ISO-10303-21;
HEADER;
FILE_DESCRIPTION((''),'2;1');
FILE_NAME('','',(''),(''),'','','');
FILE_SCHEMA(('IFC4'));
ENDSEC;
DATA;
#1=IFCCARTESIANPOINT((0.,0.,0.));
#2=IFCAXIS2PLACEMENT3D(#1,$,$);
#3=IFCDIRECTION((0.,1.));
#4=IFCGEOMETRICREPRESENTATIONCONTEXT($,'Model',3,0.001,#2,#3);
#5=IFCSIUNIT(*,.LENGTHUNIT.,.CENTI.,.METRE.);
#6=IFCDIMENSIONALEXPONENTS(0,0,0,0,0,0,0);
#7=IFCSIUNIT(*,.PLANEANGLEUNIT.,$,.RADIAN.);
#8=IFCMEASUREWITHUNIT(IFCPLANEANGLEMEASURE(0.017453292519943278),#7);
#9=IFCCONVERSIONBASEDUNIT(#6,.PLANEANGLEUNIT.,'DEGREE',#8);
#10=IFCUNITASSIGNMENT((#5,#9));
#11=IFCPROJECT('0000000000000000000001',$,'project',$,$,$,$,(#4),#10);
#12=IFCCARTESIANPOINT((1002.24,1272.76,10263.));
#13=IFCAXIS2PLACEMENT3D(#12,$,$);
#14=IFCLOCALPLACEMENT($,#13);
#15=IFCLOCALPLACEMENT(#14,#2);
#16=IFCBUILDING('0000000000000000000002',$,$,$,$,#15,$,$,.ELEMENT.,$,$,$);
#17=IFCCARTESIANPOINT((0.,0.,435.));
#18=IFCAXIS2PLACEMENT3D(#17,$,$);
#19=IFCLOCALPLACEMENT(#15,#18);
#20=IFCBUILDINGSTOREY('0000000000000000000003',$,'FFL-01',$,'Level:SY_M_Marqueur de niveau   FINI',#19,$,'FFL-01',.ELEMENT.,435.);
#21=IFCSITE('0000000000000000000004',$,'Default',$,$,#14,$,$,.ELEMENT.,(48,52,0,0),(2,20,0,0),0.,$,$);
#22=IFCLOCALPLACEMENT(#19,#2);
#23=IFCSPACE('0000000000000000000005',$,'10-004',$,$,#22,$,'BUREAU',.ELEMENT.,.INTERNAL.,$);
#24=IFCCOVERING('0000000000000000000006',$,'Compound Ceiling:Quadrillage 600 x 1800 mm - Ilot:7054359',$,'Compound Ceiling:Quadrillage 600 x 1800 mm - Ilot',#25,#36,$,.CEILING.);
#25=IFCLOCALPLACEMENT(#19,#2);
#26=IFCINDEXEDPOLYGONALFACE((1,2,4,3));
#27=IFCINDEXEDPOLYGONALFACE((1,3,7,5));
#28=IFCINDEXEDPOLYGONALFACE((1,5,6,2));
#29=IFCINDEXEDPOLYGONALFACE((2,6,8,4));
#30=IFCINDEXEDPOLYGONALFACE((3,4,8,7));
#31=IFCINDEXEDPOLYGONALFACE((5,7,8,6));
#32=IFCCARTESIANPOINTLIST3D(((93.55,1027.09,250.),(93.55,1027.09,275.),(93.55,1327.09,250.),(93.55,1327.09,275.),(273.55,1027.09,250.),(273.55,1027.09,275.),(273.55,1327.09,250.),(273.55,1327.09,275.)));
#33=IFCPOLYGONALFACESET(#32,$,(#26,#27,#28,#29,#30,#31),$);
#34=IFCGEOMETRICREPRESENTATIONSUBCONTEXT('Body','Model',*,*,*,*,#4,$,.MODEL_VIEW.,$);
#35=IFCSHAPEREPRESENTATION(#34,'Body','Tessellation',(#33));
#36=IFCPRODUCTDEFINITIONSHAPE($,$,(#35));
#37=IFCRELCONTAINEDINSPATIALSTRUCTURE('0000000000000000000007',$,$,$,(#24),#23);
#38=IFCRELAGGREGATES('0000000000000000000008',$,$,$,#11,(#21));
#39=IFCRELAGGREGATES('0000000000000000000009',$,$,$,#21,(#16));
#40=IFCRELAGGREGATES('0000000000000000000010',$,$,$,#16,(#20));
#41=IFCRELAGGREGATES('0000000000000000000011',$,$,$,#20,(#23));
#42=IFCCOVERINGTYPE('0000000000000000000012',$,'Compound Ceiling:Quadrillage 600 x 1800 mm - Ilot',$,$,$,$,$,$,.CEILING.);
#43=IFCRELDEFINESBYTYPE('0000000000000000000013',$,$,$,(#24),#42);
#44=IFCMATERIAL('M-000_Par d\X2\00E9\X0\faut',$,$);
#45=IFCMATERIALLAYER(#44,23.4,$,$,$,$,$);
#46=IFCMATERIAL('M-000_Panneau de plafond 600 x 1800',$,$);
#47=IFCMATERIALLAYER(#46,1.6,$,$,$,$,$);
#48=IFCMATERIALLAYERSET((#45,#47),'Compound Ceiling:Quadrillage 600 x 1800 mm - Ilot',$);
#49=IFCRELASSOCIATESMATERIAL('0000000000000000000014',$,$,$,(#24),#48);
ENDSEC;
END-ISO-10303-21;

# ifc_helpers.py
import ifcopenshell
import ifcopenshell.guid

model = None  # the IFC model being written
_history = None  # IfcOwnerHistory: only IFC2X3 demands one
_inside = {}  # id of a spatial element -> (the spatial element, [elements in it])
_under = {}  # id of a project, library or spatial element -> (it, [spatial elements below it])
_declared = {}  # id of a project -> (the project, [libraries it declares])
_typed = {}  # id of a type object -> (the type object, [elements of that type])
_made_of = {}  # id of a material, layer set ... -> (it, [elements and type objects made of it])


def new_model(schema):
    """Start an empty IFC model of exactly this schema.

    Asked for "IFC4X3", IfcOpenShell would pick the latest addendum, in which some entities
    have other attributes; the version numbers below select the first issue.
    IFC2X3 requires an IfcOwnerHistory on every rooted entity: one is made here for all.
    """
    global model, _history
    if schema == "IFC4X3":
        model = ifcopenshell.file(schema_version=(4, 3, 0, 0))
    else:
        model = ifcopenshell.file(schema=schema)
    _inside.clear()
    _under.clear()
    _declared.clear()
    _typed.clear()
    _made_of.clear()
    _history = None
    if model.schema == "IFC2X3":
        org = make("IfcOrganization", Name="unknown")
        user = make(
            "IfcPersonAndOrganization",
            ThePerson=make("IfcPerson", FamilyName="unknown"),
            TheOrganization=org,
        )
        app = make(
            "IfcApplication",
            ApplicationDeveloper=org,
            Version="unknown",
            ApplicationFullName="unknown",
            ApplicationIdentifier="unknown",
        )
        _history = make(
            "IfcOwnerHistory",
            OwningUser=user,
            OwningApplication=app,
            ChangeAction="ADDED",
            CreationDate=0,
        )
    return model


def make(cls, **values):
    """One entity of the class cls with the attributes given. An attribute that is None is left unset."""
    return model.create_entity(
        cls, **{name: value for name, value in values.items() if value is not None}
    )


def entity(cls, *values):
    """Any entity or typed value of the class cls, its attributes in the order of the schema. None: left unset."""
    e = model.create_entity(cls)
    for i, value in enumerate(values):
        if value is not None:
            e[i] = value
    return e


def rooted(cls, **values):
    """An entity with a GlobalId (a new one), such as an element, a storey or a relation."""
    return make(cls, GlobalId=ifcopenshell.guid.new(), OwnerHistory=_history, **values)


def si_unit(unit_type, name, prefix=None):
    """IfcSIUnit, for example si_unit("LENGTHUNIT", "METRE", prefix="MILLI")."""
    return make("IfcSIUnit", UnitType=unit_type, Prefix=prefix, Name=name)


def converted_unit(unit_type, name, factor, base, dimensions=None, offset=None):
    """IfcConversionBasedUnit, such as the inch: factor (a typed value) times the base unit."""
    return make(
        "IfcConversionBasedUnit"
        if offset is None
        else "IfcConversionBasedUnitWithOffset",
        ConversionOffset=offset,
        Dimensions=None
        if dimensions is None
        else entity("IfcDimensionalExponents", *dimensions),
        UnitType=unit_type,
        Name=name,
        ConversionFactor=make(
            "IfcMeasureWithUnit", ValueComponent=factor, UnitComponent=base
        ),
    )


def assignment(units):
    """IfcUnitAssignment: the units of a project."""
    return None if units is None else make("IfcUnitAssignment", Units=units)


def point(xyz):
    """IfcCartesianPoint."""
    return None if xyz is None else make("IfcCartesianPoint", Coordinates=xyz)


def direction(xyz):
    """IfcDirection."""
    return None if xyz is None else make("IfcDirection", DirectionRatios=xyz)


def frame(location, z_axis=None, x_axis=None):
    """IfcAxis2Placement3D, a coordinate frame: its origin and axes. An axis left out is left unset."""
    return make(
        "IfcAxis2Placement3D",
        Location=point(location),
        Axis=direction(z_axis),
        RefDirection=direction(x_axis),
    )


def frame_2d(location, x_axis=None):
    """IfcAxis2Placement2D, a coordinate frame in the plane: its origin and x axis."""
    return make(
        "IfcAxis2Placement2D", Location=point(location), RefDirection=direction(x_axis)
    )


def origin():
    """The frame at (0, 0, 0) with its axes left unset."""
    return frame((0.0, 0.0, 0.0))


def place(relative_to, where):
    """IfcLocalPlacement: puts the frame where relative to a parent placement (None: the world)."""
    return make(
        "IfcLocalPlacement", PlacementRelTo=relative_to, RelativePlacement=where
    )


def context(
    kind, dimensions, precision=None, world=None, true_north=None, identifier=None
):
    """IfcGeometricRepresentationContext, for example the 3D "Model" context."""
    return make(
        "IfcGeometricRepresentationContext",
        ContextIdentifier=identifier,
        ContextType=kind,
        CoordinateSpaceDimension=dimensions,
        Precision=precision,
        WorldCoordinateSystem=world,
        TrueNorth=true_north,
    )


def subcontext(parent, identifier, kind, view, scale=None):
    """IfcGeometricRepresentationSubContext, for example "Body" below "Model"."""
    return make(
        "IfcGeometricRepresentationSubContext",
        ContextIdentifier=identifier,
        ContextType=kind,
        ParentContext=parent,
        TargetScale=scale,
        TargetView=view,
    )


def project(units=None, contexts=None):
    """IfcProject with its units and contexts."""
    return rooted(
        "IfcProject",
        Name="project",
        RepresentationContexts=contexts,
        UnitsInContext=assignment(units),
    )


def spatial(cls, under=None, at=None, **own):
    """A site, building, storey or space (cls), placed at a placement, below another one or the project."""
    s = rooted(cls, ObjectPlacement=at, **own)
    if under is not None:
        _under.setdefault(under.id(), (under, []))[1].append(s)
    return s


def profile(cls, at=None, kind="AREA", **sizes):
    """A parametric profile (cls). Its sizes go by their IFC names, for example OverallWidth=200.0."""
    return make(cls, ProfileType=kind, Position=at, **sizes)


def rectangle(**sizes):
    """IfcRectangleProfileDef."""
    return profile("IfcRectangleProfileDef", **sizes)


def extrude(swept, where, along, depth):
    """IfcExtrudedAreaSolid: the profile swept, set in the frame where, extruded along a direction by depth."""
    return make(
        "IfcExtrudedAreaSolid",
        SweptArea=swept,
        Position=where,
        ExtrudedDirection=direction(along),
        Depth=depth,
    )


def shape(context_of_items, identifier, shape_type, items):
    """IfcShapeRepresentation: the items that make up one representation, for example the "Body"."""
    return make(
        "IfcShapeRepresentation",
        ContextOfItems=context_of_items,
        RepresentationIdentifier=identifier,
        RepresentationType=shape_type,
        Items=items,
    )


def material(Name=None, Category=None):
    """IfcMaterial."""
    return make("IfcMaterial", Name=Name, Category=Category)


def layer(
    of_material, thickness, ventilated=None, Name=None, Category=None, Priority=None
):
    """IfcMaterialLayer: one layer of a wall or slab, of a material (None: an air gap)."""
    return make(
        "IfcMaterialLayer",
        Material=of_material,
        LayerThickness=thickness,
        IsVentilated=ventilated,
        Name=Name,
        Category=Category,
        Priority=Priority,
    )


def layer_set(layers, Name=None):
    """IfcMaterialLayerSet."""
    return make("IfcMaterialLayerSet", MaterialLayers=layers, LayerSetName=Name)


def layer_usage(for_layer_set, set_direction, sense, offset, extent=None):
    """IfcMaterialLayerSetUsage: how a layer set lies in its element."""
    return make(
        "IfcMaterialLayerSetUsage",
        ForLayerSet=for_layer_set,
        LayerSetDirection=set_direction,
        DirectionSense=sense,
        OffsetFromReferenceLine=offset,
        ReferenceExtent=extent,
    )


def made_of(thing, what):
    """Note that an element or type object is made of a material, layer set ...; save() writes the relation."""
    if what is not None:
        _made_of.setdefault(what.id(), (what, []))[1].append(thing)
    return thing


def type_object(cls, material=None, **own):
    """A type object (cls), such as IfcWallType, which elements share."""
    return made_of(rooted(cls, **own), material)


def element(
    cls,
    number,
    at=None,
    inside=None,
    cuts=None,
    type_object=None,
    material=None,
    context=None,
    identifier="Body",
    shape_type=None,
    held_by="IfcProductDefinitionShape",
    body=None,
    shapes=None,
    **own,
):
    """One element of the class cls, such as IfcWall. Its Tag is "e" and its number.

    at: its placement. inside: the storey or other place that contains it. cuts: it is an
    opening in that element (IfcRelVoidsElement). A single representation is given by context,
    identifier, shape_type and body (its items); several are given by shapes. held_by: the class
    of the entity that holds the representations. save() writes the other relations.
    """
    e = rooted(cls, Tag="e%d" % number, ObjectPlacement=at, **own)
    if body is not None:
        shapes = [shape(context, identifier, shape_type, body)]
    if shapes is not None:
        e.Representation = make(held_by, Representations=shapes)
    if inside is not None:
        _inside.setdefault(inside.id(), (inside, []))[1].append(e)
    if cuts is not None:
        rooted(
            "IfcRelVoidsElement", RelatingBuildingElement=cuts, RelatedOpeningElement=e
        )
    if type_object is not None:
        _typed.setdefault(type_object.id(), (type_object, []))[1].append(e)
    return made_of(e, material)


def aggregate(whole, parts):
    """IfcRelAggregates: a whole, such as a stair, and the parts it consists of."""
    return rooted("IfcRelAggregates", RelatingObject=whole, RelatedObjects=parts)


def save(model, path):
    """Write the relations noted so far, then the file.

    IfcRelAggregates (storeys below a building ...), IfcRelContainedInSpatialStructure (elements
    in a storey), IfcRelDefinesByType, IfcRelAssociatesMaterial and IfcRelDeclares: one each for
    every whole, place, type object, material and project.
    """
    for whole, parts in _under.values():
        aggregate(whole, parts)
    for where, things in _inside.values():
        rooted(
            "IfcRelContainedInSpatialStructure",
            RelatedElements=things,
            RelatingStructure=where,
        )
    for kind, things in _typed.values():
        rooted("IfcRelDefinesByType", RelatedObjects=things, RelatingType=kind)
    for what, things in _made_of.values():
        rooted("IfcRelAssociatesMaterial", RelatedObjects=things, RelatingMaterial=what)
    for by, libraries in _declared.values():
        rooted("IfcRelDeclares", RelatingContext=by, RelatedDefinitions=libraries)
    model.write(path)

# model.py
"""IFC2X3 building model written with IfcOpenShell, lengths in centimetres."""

from ifc_helpers import new_model, entity, si_unit, converted_unit, direction, frame, frame_2d, origin, place, context, subcontext, project, spatial, rectangle, extrude, material, layer, layer_set, layer_usage, type_object, element, save


model = new_model("IFC2X3")

# Units and contexts
model_context = context("Model", 3, precision=0.001, world=origin(), true_north=direction((0.0, 1.0)))
body_context = subcontext(model_context, "Body", "Model", "MODEL_VIEW")
ifc_project = project(units=[si_unit("LENGTHUNIT", "METRE", prefix="CENTI"), converted_unit("PLANEANGLEUNIT", "DEGREE", entity("IfcPlaneAngleMeasure", 0.017453292519943278), si_unit("PLANEANGLEUNIT", "RADIAN"), dimensions=[0, 0, 0, 0, 0, 0, 0])], contexts=[model_context])

# Site, building, storey
site_placement = place(None, frame((1002.24, 1272.76, 10263.0)))
site = spatial("IfcSite", under=ifc_project, at=site_placement, Name="Default", CompositionType="ELEMENT", RefLatitude=(48, 52, 0, 0), RefLongitude=(2, 20, 0, 0), RefElevation=0.0)
building_placement = place(site_placement, origin())
building = spatial("IfcBuilding", under=site, at=building_placement, CompositionType="ELEMENT")
storey_placement = place(building_placement, frame((0.0, 0.0, 435.0)))
storey = spatial("IfcBuildingStorey", under=building, at=storey_placement, Name="FFL-01", ObjectType="Level:SY_M_Marqueur de niveau   FINI", LongName="FFL-01", CompositionType="ELEMENT", Elevation=435.0)

# Shared definitions
ifc_material_1 = material(Name="M-000_Par défaut")

# Shared definitions
ifc_layer_1 = layer(ifc_material_1, 23.4)
ifc_material_2 = material(Name="M-000_Panneau de plafond 600 x 1800")
ifc_layer_2 = layer(ifc_material_2, 1.6)
ifc_layer_set_1 = layer_set([ifc_layer_1, ifc_layer_2], Name="Compound Ceiling:Quadrillage 600 x 1800 mm - Ilot")
covering_type_1 = type_object("IfcCoveringType", Name="Compound Ceiling:Quadrillage 600 x 1800 mm - Ilot", PredefinedType="CEILING")

# Shared definitions
space_1_placement = place(storey_placement, origin())
space_1 = spatial("IfcSpace", under=storey, at=space_1_placement, Name="10-004", LongName="BUREAU", CompositionType="ELEMENT", InteriorOrExteriorSpace="INTERNAL")

# Covering
ifc_layer_usage_1 = layer_usage(ifc_layer_set_1, "AXIS3", "NEGATIVE", 25.0)
covering_1_placement = place(space_1_placement, origin())
element("IfcCovering", 1, at=covering_1_placement, inside=space_1, type_object=covering_type_1, material=ifc_layer_usage_1, Name="Compound Ceiling:Quadrillage 600 x 1800 mm - Ilot:7054359", ObjectType="Compound Ceiling:Quadrillage 600 x 1800 mm - Ilot", PredefinedType="CEILING", context=body_context, shape_type="SweptSolid", body=[
    extrude(rectangle(XDim=300.0, YDim=180.0, at=frame_2d((0.0, 0.0), x_axis=(1.0, 0.0))), frame((183.55, 1177.09, 250.0), z_axis=(0.0, 0.0, 1.0), x_axis=(0.0, -1.0, 0.0)), (0.0, 0.0, 1.0), 25.0),
])

save(model, "model.ifc")
